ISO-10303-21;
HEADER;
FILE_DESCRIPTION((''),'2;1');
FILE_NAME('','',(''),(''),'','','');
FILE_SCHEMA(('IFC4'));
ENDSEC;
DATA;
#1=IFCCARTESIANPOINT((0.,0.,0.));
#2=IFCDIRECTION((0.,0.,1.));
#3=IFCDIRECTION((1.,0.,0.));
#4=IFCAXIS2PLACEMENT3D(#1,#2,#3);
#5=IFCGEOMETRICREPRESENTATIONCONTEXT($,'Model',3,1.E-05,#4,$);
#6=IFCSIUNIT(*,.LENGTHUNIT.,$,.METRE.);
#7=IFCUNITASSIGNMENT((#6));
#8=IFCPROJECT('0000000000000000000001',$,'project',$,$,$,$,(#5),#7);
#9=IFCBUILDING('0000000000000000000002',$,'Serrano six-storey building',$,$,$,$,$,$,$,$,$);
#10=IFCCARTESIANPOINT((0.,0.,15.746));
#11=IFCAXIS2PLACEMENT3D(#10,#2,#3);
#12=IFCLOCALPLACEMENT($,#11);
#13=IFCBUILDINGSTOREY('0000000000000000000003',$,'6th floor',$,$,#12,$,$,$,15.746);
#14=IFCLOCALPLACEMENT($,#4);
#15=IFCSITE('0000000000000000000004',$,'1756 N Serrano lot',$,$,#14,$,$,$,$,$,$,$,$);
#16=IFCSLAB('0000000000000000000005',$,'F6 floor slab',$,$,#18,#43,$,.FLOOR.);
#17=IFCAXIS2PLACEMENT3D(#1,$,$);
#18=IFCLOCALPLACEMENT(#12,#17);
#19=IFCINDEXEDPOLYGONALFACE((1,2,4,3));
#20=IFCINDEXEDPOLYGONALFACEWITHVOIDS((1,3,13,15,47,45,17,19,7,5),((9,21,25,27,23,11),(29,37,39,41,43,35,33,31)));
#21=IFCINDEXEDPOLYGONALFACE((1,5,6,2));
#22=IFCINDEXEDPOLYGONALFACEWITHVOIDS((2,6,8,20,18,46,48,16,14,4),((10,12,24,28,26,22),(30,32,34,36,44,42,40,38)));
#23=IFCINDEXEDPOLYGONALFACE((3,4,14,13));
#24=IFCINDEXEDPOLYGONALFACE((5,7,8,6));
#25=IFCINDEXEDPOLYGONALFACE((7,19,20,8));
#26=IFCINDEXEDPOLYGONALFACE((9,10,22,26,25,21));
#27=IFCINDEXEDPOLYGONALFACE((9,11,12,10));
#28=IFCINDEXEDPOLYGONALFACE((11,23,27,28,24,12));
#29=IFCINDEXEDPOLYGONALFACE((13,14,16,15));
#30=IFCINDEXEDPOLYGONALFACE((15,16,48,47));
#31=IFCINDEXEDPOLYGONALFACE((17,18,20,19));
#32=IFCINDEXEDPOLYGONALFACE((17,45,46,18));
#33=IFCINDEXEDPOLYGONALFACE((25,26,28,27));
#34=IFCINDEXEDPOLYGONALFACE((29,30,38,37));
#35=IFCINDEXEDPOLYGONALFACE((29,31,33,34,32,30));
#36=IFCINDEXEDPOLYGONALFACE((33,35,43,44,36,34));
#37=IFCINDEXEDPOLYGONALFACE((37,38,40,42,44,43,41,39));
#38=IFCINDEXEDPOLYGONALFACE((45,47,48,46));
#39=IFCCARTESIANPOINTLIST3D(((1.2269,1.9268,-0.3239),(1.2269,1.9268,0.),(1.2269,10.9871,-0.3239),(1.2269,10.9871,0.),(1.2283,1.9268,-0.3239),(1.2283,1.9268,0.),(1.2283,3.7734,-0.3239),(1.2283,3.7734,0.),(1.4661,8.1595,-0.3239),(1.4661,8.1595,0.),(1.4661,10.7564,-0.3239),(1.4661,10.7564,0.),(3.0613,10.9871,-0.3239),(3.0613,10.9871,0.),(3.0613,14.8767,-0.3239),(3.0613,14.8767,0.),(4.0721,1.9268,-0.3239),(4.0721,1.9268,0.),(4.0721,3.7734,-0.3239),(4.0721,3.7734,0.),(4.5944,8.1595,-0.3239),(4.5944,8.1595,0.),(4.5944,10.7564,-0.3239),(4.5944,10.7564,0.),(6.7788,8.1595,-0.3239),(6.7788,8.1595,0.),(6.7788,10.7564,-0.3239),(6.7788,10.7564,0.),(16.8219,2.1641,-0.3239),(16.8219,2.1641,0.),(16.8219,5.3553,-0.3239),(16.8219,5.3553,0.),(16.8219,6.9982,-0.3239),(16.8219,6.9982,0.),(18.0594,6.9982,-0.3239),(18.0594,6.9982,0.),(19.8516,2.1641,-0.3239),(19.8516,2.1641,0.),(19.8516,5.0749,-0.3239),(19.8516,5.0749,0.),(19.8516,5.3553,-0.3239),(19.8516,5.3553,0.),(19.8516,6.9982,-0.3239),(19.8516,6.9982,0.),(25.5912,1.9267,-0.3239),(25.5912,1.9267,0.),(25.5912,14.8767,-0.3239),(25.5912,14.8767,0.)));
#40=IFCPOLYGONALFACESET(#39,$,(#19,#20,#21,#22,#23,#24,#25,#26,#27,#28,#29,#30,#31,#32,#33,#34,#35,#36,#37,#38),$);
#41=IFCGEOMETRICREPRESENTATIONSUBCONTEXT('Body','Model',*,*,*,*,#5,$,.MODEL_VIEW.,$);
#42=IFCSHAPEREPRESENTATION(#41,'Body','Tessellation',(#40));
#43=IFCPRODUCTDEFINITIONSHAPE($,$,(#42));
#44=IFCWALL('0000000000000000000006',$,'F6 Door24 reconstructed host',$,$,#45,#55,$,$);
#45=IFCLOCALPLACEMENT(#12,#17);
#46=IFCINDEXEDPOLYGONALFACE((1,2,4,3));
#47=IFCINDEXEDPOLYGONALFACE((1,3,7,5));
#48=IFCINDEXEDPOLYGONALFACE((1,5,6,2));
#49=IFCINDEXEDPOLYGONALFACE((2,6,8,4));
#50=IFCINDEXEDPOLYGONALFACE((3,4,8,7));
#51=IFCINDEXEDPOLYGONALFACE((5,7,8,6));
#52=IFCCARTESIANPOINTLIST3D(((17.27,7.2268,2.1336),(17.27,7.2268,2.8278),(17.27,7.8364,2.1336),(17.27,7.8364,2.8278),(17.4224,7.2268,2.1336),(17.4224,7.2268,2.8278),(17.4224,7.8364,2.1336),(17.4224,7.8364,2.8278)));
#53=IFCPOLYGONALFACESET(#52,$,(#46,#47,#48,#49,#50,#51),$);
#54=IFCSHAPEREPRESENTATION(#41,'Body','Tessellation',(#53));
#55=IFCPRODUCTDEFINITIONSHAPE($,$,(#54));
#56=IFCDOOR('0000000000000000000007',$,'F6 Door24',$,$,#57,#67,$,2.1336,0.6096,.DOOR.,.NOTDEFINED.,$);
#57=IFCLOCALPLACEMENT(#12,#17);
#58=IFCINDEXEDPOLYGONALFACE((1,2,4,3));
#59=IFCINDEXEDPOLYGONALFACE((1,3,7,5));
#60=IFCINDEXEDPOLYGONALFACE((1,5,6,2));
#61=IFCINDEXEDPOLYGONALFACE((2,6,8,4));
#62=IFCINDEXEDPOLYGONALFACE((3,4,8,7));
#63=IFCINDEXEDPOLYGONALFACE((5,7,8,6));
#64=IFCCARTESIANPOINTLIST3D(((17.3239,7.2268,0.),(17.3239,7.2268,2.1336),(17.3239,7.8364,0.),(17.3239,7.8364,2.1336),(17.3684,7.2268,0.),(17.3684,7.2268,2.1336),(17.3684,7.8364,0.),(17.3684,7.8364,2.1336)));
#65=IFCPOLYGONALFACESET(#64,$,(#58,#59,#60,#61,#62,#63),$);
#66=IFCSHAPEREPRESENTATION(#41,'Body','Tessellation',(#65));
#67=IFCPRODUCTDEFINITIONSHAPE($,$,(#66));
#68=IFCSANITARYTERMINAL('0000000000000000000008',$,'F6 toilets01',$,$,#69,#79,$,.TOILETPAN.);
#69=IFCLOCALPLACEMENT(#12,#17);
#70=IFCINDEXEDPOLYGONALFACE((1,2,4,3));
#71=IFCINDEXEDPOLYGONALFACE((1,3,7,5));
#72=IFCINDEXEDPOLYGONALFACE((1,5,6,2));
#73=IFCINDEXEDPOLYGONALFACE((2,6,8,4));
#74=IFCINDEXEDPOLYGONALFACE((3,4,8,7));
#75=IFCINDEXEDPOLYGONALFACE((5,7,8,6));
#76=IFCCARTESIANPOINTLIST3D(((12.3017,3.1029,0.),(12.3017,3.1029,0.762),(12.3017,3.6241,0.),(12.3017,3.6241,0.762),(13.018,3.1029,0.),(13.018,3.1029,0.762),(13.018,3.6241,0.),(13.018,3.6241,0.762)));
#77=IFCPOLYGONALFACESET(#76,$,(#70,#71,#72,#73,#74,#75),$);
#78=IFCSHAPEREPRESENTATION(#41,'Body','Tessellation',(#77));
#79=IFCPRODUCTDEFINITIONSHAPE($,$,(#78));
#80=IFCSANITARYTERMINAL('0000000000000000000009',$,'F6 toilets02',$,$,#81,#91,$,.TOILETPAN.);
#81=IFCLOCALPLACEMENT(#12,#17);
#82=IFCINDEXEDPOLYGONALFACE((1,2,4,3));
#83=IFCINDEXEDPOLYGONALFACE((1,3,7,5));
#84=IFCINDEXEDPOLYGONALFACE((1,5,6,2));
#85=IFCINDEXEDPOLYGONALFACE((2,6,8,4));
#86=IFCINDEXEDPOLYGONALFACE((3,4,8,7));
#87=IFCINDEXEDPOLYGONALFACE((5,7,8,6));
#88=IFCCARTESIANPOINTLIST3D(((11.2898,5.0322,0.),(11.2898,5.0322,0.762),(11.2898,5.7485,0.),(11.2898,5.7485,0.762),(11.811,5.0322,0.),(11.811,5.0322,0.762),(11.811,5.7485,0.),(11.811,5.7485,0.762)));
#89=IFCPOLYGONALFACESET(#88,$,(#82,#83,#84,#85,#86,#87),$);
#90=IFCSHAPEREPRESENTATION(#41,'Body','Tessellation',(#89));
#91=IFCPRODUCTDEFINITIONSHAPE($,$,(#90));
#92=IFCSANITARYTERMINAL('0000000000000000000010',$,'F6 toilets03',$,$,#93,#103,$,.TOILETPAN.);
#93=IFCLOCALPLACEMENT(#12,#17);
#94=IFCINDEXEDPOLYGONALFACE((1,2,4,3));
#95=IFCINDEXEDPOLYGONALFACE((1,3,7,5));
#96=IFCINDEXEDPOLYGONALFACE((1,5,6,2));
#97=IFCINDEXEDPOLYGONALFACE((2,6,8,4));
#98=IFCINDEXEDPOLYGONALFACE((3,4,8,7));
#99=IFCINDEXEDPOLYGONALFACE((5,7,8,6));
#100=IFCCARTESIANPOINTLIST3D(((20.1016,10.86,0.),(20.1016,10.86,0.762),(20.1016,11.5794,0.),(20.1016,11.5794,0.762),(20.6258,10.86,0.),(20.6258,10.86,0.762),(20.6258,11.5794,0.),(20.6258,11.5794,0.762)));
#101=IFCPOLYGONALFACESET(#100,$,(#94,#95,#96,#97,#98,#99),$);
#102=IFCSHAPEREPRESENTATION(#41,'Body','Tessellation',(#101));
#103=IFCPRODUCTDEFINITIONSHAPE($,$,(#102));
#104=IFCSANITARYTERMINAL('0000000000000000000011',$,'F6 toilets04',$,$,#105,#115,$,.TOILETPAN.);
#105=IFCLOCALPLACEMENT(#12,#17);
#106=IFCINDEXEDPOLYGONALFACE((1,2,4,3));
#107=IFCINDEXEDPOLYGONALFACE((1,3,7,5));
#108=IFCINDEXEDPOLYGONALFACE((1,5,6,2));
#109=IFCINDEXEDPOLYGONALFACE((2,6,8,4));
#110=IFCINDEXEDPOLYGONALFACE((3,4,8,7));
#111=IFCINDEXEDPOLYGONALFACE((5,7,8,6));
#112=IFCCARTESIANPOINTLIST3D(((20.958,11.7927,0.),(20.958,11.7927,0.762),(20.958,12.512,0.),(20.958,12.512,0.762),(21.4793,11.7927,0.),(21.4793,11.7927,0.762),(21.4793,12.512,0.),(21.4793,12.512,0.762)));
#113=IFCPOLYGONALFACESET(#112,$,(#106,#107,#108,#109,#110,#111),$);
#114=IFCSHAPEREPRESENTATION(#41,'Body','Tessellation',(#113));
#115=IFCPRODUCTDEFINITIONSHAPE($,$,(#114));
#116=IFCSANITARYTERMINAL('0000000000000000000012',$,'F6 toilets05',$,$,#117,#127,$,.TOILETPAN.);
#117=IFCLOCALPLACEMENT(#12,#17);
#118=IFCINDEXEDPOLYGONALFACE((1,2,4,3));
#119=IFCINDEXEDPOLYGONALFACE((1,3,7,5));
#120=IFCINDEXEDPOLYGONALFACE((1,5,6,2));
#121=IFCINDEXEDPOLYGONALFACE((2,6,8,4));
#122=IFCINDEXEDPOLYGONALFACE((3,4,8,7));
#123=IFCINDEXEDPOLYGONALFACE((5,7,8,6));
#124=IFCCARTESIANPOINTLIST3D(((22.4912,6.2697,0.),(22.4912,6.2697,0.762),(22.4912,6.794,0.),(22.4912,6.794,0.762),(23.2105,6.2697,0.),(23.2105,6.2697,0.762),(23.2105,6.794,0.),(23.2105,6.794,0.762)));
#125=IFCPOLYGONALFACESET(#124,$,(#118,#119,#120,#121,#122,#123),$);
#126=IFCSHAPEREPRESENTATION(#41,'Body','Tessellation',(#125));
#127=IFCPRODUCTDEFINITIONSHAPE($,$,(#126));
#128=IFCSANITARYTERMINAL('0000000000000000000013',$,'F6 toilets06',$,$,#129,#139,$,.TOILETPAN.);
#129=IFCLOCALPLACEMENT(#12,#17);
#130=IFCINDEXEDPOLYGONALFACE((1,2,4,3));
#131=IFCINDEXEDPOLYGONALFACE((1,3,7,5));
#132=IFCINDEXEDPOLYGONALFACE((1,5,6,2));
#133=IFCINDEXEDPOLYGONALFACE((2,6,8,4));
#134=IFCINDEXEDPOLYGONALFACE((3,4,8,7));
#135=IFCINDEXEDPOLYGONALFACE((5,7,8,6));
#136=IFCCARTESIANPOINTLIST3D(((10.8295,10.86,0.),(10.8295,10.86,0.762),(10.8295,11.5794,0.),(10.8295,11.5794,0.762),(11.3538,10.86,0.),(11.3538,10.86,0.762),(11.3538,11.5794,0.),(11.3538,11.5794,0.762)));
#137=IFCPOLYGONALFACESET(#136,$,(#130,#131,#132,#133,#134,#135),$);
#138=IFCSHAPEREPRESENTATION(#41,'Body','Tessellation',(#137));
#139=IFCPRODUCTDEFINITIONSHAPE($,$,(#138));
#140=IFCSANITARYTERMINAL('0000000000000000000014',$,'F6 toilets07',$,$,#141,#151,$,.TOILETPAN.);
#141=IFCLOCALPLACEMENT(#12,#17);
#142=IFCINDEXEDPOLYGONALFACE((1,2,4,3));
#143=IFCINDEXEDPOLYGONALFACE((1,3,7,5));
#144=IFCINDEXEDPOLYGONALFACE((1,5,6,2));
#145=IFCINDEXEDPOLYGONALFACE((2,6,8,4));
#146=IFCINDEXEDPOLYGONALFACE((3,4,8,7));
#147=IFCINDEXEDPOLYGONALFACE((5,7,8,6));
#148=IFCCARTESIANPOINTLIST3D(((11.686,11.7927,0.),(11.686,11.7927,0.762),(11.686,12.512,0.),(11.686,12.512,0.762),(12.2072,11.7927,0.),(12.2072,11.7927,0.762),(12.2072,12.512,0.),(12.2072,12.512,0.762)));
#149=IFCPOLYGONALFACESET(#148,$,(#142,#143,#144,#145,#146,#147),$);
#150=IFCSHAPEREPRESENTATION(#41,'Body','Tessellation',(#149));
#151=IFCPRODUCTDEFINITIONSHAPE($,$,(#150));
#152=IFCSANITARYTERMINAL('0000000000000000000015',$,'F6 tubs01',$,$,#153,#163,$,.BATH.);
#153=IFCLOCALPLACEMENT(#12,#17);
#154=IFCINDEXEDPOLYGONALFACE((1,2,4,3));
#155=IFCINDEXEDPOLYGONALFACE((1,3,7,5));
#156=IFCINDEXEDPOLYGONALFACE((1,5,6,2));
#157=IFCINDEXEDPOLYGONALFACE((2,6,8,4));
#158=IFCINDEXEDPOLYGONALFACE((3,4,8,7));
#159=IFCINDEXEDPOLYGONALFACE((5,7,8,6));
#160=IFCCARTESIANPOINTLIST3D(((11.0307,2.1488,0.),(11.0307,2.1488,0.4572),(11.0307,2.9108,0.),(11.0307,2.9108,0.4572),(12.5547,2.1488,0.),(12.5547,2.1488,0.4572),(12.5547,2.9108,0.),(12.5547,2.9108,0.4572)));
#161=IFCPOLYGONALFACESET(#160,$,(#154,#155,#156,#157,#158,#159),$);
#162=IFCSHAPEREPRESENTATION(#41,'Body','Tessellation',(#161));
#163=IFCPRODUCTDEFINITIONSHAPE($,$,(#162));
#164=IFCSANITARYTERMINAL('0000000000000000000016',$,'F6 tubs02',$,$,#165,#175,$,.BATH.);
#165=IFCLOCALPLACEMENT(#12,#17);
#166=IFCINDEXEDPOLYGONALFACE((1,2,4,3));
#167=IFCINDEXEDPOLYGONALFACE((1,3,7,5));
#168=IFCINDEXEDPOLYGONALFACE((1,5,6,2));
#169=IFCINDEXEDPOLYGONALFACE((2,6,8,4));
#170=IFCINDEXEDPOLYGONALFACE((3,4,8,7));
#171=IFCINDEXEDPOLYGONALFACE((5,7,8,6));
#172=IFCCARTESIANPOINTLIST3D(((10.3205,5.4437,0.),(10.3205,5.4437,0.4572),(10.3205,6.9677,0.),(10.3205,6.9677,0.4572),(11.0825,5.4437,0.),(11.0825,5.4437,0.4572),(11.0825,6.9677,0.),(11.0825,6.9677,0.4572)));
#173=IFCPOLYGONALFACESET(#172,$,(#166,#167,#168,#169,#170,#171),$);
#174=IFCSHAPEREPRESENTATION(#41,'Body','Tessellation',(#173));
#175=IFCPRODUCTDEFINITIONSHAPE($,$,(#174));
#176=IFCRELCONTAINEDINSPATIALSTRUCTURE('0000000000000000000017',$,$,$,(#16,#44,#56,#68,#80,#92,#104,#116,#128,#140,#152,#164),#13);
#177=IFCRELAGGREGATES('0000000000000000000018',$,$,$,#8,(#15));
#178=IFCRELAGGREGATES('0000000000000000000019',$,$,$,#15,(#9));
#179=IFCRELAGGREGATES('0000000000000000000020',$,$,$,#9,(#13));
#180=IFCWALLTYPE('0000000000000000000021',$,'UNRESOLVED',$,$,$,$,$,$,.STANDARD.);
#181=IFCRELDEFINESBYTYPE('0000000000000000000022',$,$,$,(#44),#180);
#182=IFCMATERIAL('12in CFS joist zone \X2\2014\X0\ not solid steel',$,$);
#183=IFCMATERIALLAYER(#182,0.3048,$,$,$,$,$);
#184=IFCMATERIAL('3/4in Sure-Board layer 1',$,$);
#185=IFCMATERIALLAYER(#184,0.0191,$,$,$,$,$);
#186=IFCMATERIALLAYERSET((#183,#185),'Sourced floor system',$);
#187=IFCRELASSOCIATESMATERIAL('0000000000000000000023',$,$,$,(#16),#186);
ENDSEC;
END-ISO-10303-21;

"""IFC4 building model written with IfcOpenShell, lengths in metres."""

from ifc_helpers import new_model, si_unit, frame, origin_with_axes, place, context, subcontext, project, spatial, polyline, outline, extrude, material, layer, layer_set, type_object, element, fill, save


model = new_model("IFC4")

# Units and contexts
model_context = context("Model", 3, precision=1e-05, world=origin_with_axes())
body_context = subcontext(model_context, "Body", "Model", "MODEL_VIEW")
ifc_project = project(units=[si_unit("LENGTHUNIT", "METRE")], contexts=[model_context])

# Site, building, storey
site_placement = place(None, origin_with_axes())
site = spatial("IfcSite", under=ifc_project, at=site_placement, Name="1756 N Serrano lot")
building = spatial("IfcBuilding", under=site, Name="Serrano six-storey building")
storey_placement = place(None, frame((0.0, 0.0, 15.746), z_axis=(0.0, 0.0, 1.0), x_axis=(1.0, 0.0, 0.0)))
storey = spatial("IfcBuildingStorey", under=building, at=storey_placement, Name="6th floor", Elevation=15.746)

# Slab
ifc_material_1 = material(Name="12in CFS joist zone — not solid steel")
ifc_layer_1 = layer(ifc_material_1, 0.3048)
ifc_material_2 = material(Name="3/4in Sure-Board layer 1")
ifc_layer_2 = layer(ifc_material_2, 0.0191)
ifc_layer_set = layer_set([ifc_layer_1, ifc_layer_2], Name="Sourced floor system")
slab_placement = place(storey_placement, frame((0.0, 0.0, -15.746), z_axis=(0.0, 0.0, 1.0), x_axis=(1.0, 0.0, 0.0)))
element("IfcSlab", 1, at=slab_placement, inside=storey, material=ifc_layer_set, Name="F6 floor slab", PredefinedType="FLOOR", context=body_context, shape_type="SweptSolid", body=[
    extrude(outline(polyline([(3.0613, 14.8767), (25.5912, 14.8767), (25.5912, 1.9267), (4.0721, 1.9268), (4.0721, 3.7734), (1.2283, 3.7734), (1.2283, 1.9268), (1.2269, 1.9268), (1.2269, 10.9871), (3.0613, 10.9871), (3.0613, 14.8767)]), holes=[polyline([(6.7788, 10.7564), (4.5944, 10.7564), (1.4661, 10.7564), (1.4661, 8.1595), (4.5944, 8.1595), (6.7788, 8.1595), (6.7788, 10.7564)]), polyline([(16.8219, 5.3553), (16.8219, 2.1641), (19.8516, 2.1641), (19.8516, 5.0749), (19.8516, 5.3553), (19.8516, 6.9982), (18.0594, 6.9982), (16.8219, 6.9982), (16.8219, 5.3553)])]), frame((0.0, 0.0, 15.4221)), (0.0, 0.0, 1.0), 0.3239),
])

# Wall, opening, door
wall_type = type_object("IfcWallType", Name="UNRESOLVED", PredefinedType="STANDARD")
wall_placement = place(storey_placement, frame((0.0, 0.0, -15.746), z_axis=(0.0, 0.0, 1.0), x_axis=(1.0, 0.0, 0.0)))
wall = element("IfcWall", 2, at=wall_placement, inside=storey, type_object=wall_type, Name="F6 Door24 reconstructed host", context=body_context, shape_type="SweptSolid", body=[
    extrude(outline(polyline([(17.27, 7.8364), (17.4224, 7.8364), (17.4224, 7.2268), (17.27, 7.2268), (17.27, 7.8364)])), frame((0.0, 0.0, 15.746)), (0.0, 0.0, 1.0), 2.8278),
])
opening_placement = place(None, origin_with_axes())
opening = element("IfcOpeningElement", 3, at=opening_placement, cuts=wall, PredefinedType="OPENING", context=body_context, shape_type="SweptSolid", body=[
    extrude(outline(polyline([(17.2517, 7.8364), (17.4407, 7.8364), (17.4407, 7.2268), (17.2517, 7.2268), (17.2517, 7.8364)])), frame((0.0, 0.0, 15.746)), (0.0, 0.0, 1.0), 2.1336),
])
door_placement = place(storey_placement, frame((0.0, 0.0, -15.746), z_axis=(0.0, 0.0, 1.0), x_axis=(1.0, 0.0, 0.0)))
door = element("IfcDoor", 4, at=door_placement, inside=storey, Name="F6 Door24", OperationType="NOTDEFINED", OverallHeight=2.1336, OverallWidth=0.6096, PredefinedType="DOOR", context=body_context, shape_type="SweptSolid", body=[
    extrude(outline(polyline([(17.3239, 7.8364), (17.3684, 7.8364), (17.3684, 7.2268), (17.3239, 7.2268), (17.3239, 7.8364)])), frame((0.0, 0.0, 15.746)), (0.0, 0.0, 1.0), 2.1336),
])
fill(opening, door)

# Sanitary terminals
sanitary_terminal_1_placement = place(storey_placement, frame((0.0, 0.0, -15.746), z_axis=(0.0, 0.0, 1.0), x_axis=(1.0, 0.0, 0.0)))
element("IfcSanitaryTerminal", 5, at=sanitary_terminal_1_placement, inside=storey, Name="F6 toilets01", PredefinedType="TOILETPAN", context=body_context, shape_type="SweptSolid", body=[
    extrude(outline(polyline([(13.018, 3.1029), (13.018, 3.6241), (12.3017, 3.6241), (12.3017, 3.1029), (13.018, 3.1029)])), frame((0.0, 0.0, 15.746)), (0.0, 0.0, 1.0), 0.762),
])
sanitary_terminal_2_placement = place(storey_placement, frame((0.0, 0.0, -15.746), z_axis=(0.0, 0.0, 1.0), x_axis=(1.0, 0.0, 0.0)))
element("IfcSanitaryTerminal", 6, at=sanitary_terminal_2_placement, inside=storey, Name="F6 toilets02", PredefinedType="TOILETPAN", context=body_context, shape_type="SweptSolid", body=[
    extrude(outline(polyline([(11.811, 5.0322), (11.811, 5.7485), (11.2898, 5.7485), (11.2898, 5.0322), (11.811, 5.0322)])), frame((0.0, 0.0, 15.746)), (0.0, 0.0, 1.0), 0.762),
])
sanitary_terminal_3_placement = place(storey_placement, frame((0.0, 0.0, -15.746), z_axis=(0.0, 0.0, 1.0), x_axis=(1.0, 0.0, 0.0)))
element("IfcSanitaryTerminal", 7, at=sanitary_terminal_3_placement, inside=storey, Name="F6 toilets03", PredefinedType="TOILETPAN", context=body_context, shape_type="SweptSolid", body=[
    extrude(outline(polyline([(20.6258, 10.86), (20.6258, 11.5794), (20.1016, 11.5794), (20.1016, 10.86), (20.6258, 10.86)])), frame((0.0, 0.0, 15.746)), (0.0, 0.0, 1.0), 0.762),
])
sanitary_terminal_4_placement = place(storey_placement, frame((0.0, 0.0, -15.746), z_axis=(0.0, 0.0, 1.0), x_axis=(1.0, 0.0, 0.0)))
element("IfcSanitaryTerminal", 8, at=sanitary_terminal_4_placement, inside=storey, Name="F6 toilets04", PredefinedType="TOILETPAN", context=body_context, shape_type="SweptSolid", body=[
    extrude(outline(polyline([(21.4793, 11.7927), (21.4793, 12.512), (20.958, 12.512), (20.958, 11.7927), (21.4793, 11.7927)])), frame((0.0, 0.0, 15.746)), (0.0, 0.0, 1.0), 0.762),
])
sanitary_terminal_5_placement = place(storey_placement, frame((0.0, 0.0, -15.746), z_axis=(0.0, 0.0, 1.0), x_axis=(1.0, 0.0, 0.0)))
element("IfcSanitaryTerminal", 9, at=sanitary_terminal_5_placement, inside=storey, Name="F6 toilets05", PredefinedType="TOILETPAN", context=body_context, shape_type="SweptSolid", body=[
    extrude(outline(polyline([(23.2105, 6.2697), (23.2105, 6.794), (22.4912, 6.794), (22.4912, 6.2697), (23.2105, 6.2697)])), frame((0.0, 0.0, 15.746)), (0.0, 0.0, 1.0), 0.762),
])
sanitary_terminal_6_placement = place(storey_placement, frame((0.0, 0.0, -15.746), z_axis=(0.0, 0.0, 1.0), x_axis=(1.0, 0.0, 0.0)))
element("IfcSanitaryTerminal", 10, at=sanitary_terminal_6_placement, inside=storey, Name="F6 toilets06", PredefinedType="TOILETPAN", context=body_context, shape_type="SweptSolid", body=[
    extrude(outline(polyline([(11.3538, 10.86), (11.3538, 11.5794), (10.8295, 11.5794), (10.8295, 10.86), (11.3538, 10.86)])), frame((0.0, 0.0, 15.746)), (0.0, 0.0, 1.0), 0.762),
])
sanitary_terminal_7_placement = place(storey_placement, frame((0.0, 0.0, -15.746), z_axis=(0.0, 0.0, 1.0), x_axis=(1.0, 0.0, 0.0)))
element("IfcSanitaryTerminal", 11, at=sanitary_terminal_7_placement, inside=storey, Name="F6 toilets07", PredefinedType="TOILETPAN", context=body_context, shape_type="SweptSolid", body=[
    extrude(outline(polyline([(12.2072, 11.7927), (12.2072, 12.512), (11.686, 12.512), (11.686, 11.7927), (12.2072, 11.7927)])), frame((0.0, 0.0, 15.746)), (0.0, 0.0, 1.0), 0.762),
])
sanitary_terminal_8_placement = place(storey_placement, frame((0.0, 0.0, -15.746), z_axis=(0.0, 0.0, 1.0), x_axis=(1.0, 0.0, 0.0)))
element("IfcSanitaryTerminal", 12, at=sanitary_terminal_8_placement, inside=storey, Name="F6 tubs01", PredefinedType="BATH", context=body_context, shape_type="SweptSolid", body=[
    extrude(outline(polyline([(12.5547, 2.1488), (12.5547, 2.9108), (11.0307, 2.9108), (11.0307, 2.1488), (12.5547, 2.1488)])), frame((0.0, 0.0, 15.746)), (0.0, 0.0, 1.0), 0.4572),
])
sanitary_terminal_9_placement = place(storey_placement, frame((0.0, 0.0, -15.746), z_axis=(0.0, 0.0, 1.0), x_axis=(1.0, 0.0, 0.0)))
element("IfcSanitaryTerminal", 13, at=sanitary_terminal_9_placement, inside=storey, Name="F6 tubs02", PredefinedType="BATH", context=body_context, shape_type="SweptSolid", body=[
    extrude(outline(polyline([(11.0825, 5.4437), (11.0825, 6.9677), (10.3205, 6.9677), (10.3205, 5.4437), (11.0825, 5.4437)])), frame((0.0, 0.0, 15.746)), (0.0, 0.0, 1.0), 0.4572),
])

save(model, "model.ifc")
